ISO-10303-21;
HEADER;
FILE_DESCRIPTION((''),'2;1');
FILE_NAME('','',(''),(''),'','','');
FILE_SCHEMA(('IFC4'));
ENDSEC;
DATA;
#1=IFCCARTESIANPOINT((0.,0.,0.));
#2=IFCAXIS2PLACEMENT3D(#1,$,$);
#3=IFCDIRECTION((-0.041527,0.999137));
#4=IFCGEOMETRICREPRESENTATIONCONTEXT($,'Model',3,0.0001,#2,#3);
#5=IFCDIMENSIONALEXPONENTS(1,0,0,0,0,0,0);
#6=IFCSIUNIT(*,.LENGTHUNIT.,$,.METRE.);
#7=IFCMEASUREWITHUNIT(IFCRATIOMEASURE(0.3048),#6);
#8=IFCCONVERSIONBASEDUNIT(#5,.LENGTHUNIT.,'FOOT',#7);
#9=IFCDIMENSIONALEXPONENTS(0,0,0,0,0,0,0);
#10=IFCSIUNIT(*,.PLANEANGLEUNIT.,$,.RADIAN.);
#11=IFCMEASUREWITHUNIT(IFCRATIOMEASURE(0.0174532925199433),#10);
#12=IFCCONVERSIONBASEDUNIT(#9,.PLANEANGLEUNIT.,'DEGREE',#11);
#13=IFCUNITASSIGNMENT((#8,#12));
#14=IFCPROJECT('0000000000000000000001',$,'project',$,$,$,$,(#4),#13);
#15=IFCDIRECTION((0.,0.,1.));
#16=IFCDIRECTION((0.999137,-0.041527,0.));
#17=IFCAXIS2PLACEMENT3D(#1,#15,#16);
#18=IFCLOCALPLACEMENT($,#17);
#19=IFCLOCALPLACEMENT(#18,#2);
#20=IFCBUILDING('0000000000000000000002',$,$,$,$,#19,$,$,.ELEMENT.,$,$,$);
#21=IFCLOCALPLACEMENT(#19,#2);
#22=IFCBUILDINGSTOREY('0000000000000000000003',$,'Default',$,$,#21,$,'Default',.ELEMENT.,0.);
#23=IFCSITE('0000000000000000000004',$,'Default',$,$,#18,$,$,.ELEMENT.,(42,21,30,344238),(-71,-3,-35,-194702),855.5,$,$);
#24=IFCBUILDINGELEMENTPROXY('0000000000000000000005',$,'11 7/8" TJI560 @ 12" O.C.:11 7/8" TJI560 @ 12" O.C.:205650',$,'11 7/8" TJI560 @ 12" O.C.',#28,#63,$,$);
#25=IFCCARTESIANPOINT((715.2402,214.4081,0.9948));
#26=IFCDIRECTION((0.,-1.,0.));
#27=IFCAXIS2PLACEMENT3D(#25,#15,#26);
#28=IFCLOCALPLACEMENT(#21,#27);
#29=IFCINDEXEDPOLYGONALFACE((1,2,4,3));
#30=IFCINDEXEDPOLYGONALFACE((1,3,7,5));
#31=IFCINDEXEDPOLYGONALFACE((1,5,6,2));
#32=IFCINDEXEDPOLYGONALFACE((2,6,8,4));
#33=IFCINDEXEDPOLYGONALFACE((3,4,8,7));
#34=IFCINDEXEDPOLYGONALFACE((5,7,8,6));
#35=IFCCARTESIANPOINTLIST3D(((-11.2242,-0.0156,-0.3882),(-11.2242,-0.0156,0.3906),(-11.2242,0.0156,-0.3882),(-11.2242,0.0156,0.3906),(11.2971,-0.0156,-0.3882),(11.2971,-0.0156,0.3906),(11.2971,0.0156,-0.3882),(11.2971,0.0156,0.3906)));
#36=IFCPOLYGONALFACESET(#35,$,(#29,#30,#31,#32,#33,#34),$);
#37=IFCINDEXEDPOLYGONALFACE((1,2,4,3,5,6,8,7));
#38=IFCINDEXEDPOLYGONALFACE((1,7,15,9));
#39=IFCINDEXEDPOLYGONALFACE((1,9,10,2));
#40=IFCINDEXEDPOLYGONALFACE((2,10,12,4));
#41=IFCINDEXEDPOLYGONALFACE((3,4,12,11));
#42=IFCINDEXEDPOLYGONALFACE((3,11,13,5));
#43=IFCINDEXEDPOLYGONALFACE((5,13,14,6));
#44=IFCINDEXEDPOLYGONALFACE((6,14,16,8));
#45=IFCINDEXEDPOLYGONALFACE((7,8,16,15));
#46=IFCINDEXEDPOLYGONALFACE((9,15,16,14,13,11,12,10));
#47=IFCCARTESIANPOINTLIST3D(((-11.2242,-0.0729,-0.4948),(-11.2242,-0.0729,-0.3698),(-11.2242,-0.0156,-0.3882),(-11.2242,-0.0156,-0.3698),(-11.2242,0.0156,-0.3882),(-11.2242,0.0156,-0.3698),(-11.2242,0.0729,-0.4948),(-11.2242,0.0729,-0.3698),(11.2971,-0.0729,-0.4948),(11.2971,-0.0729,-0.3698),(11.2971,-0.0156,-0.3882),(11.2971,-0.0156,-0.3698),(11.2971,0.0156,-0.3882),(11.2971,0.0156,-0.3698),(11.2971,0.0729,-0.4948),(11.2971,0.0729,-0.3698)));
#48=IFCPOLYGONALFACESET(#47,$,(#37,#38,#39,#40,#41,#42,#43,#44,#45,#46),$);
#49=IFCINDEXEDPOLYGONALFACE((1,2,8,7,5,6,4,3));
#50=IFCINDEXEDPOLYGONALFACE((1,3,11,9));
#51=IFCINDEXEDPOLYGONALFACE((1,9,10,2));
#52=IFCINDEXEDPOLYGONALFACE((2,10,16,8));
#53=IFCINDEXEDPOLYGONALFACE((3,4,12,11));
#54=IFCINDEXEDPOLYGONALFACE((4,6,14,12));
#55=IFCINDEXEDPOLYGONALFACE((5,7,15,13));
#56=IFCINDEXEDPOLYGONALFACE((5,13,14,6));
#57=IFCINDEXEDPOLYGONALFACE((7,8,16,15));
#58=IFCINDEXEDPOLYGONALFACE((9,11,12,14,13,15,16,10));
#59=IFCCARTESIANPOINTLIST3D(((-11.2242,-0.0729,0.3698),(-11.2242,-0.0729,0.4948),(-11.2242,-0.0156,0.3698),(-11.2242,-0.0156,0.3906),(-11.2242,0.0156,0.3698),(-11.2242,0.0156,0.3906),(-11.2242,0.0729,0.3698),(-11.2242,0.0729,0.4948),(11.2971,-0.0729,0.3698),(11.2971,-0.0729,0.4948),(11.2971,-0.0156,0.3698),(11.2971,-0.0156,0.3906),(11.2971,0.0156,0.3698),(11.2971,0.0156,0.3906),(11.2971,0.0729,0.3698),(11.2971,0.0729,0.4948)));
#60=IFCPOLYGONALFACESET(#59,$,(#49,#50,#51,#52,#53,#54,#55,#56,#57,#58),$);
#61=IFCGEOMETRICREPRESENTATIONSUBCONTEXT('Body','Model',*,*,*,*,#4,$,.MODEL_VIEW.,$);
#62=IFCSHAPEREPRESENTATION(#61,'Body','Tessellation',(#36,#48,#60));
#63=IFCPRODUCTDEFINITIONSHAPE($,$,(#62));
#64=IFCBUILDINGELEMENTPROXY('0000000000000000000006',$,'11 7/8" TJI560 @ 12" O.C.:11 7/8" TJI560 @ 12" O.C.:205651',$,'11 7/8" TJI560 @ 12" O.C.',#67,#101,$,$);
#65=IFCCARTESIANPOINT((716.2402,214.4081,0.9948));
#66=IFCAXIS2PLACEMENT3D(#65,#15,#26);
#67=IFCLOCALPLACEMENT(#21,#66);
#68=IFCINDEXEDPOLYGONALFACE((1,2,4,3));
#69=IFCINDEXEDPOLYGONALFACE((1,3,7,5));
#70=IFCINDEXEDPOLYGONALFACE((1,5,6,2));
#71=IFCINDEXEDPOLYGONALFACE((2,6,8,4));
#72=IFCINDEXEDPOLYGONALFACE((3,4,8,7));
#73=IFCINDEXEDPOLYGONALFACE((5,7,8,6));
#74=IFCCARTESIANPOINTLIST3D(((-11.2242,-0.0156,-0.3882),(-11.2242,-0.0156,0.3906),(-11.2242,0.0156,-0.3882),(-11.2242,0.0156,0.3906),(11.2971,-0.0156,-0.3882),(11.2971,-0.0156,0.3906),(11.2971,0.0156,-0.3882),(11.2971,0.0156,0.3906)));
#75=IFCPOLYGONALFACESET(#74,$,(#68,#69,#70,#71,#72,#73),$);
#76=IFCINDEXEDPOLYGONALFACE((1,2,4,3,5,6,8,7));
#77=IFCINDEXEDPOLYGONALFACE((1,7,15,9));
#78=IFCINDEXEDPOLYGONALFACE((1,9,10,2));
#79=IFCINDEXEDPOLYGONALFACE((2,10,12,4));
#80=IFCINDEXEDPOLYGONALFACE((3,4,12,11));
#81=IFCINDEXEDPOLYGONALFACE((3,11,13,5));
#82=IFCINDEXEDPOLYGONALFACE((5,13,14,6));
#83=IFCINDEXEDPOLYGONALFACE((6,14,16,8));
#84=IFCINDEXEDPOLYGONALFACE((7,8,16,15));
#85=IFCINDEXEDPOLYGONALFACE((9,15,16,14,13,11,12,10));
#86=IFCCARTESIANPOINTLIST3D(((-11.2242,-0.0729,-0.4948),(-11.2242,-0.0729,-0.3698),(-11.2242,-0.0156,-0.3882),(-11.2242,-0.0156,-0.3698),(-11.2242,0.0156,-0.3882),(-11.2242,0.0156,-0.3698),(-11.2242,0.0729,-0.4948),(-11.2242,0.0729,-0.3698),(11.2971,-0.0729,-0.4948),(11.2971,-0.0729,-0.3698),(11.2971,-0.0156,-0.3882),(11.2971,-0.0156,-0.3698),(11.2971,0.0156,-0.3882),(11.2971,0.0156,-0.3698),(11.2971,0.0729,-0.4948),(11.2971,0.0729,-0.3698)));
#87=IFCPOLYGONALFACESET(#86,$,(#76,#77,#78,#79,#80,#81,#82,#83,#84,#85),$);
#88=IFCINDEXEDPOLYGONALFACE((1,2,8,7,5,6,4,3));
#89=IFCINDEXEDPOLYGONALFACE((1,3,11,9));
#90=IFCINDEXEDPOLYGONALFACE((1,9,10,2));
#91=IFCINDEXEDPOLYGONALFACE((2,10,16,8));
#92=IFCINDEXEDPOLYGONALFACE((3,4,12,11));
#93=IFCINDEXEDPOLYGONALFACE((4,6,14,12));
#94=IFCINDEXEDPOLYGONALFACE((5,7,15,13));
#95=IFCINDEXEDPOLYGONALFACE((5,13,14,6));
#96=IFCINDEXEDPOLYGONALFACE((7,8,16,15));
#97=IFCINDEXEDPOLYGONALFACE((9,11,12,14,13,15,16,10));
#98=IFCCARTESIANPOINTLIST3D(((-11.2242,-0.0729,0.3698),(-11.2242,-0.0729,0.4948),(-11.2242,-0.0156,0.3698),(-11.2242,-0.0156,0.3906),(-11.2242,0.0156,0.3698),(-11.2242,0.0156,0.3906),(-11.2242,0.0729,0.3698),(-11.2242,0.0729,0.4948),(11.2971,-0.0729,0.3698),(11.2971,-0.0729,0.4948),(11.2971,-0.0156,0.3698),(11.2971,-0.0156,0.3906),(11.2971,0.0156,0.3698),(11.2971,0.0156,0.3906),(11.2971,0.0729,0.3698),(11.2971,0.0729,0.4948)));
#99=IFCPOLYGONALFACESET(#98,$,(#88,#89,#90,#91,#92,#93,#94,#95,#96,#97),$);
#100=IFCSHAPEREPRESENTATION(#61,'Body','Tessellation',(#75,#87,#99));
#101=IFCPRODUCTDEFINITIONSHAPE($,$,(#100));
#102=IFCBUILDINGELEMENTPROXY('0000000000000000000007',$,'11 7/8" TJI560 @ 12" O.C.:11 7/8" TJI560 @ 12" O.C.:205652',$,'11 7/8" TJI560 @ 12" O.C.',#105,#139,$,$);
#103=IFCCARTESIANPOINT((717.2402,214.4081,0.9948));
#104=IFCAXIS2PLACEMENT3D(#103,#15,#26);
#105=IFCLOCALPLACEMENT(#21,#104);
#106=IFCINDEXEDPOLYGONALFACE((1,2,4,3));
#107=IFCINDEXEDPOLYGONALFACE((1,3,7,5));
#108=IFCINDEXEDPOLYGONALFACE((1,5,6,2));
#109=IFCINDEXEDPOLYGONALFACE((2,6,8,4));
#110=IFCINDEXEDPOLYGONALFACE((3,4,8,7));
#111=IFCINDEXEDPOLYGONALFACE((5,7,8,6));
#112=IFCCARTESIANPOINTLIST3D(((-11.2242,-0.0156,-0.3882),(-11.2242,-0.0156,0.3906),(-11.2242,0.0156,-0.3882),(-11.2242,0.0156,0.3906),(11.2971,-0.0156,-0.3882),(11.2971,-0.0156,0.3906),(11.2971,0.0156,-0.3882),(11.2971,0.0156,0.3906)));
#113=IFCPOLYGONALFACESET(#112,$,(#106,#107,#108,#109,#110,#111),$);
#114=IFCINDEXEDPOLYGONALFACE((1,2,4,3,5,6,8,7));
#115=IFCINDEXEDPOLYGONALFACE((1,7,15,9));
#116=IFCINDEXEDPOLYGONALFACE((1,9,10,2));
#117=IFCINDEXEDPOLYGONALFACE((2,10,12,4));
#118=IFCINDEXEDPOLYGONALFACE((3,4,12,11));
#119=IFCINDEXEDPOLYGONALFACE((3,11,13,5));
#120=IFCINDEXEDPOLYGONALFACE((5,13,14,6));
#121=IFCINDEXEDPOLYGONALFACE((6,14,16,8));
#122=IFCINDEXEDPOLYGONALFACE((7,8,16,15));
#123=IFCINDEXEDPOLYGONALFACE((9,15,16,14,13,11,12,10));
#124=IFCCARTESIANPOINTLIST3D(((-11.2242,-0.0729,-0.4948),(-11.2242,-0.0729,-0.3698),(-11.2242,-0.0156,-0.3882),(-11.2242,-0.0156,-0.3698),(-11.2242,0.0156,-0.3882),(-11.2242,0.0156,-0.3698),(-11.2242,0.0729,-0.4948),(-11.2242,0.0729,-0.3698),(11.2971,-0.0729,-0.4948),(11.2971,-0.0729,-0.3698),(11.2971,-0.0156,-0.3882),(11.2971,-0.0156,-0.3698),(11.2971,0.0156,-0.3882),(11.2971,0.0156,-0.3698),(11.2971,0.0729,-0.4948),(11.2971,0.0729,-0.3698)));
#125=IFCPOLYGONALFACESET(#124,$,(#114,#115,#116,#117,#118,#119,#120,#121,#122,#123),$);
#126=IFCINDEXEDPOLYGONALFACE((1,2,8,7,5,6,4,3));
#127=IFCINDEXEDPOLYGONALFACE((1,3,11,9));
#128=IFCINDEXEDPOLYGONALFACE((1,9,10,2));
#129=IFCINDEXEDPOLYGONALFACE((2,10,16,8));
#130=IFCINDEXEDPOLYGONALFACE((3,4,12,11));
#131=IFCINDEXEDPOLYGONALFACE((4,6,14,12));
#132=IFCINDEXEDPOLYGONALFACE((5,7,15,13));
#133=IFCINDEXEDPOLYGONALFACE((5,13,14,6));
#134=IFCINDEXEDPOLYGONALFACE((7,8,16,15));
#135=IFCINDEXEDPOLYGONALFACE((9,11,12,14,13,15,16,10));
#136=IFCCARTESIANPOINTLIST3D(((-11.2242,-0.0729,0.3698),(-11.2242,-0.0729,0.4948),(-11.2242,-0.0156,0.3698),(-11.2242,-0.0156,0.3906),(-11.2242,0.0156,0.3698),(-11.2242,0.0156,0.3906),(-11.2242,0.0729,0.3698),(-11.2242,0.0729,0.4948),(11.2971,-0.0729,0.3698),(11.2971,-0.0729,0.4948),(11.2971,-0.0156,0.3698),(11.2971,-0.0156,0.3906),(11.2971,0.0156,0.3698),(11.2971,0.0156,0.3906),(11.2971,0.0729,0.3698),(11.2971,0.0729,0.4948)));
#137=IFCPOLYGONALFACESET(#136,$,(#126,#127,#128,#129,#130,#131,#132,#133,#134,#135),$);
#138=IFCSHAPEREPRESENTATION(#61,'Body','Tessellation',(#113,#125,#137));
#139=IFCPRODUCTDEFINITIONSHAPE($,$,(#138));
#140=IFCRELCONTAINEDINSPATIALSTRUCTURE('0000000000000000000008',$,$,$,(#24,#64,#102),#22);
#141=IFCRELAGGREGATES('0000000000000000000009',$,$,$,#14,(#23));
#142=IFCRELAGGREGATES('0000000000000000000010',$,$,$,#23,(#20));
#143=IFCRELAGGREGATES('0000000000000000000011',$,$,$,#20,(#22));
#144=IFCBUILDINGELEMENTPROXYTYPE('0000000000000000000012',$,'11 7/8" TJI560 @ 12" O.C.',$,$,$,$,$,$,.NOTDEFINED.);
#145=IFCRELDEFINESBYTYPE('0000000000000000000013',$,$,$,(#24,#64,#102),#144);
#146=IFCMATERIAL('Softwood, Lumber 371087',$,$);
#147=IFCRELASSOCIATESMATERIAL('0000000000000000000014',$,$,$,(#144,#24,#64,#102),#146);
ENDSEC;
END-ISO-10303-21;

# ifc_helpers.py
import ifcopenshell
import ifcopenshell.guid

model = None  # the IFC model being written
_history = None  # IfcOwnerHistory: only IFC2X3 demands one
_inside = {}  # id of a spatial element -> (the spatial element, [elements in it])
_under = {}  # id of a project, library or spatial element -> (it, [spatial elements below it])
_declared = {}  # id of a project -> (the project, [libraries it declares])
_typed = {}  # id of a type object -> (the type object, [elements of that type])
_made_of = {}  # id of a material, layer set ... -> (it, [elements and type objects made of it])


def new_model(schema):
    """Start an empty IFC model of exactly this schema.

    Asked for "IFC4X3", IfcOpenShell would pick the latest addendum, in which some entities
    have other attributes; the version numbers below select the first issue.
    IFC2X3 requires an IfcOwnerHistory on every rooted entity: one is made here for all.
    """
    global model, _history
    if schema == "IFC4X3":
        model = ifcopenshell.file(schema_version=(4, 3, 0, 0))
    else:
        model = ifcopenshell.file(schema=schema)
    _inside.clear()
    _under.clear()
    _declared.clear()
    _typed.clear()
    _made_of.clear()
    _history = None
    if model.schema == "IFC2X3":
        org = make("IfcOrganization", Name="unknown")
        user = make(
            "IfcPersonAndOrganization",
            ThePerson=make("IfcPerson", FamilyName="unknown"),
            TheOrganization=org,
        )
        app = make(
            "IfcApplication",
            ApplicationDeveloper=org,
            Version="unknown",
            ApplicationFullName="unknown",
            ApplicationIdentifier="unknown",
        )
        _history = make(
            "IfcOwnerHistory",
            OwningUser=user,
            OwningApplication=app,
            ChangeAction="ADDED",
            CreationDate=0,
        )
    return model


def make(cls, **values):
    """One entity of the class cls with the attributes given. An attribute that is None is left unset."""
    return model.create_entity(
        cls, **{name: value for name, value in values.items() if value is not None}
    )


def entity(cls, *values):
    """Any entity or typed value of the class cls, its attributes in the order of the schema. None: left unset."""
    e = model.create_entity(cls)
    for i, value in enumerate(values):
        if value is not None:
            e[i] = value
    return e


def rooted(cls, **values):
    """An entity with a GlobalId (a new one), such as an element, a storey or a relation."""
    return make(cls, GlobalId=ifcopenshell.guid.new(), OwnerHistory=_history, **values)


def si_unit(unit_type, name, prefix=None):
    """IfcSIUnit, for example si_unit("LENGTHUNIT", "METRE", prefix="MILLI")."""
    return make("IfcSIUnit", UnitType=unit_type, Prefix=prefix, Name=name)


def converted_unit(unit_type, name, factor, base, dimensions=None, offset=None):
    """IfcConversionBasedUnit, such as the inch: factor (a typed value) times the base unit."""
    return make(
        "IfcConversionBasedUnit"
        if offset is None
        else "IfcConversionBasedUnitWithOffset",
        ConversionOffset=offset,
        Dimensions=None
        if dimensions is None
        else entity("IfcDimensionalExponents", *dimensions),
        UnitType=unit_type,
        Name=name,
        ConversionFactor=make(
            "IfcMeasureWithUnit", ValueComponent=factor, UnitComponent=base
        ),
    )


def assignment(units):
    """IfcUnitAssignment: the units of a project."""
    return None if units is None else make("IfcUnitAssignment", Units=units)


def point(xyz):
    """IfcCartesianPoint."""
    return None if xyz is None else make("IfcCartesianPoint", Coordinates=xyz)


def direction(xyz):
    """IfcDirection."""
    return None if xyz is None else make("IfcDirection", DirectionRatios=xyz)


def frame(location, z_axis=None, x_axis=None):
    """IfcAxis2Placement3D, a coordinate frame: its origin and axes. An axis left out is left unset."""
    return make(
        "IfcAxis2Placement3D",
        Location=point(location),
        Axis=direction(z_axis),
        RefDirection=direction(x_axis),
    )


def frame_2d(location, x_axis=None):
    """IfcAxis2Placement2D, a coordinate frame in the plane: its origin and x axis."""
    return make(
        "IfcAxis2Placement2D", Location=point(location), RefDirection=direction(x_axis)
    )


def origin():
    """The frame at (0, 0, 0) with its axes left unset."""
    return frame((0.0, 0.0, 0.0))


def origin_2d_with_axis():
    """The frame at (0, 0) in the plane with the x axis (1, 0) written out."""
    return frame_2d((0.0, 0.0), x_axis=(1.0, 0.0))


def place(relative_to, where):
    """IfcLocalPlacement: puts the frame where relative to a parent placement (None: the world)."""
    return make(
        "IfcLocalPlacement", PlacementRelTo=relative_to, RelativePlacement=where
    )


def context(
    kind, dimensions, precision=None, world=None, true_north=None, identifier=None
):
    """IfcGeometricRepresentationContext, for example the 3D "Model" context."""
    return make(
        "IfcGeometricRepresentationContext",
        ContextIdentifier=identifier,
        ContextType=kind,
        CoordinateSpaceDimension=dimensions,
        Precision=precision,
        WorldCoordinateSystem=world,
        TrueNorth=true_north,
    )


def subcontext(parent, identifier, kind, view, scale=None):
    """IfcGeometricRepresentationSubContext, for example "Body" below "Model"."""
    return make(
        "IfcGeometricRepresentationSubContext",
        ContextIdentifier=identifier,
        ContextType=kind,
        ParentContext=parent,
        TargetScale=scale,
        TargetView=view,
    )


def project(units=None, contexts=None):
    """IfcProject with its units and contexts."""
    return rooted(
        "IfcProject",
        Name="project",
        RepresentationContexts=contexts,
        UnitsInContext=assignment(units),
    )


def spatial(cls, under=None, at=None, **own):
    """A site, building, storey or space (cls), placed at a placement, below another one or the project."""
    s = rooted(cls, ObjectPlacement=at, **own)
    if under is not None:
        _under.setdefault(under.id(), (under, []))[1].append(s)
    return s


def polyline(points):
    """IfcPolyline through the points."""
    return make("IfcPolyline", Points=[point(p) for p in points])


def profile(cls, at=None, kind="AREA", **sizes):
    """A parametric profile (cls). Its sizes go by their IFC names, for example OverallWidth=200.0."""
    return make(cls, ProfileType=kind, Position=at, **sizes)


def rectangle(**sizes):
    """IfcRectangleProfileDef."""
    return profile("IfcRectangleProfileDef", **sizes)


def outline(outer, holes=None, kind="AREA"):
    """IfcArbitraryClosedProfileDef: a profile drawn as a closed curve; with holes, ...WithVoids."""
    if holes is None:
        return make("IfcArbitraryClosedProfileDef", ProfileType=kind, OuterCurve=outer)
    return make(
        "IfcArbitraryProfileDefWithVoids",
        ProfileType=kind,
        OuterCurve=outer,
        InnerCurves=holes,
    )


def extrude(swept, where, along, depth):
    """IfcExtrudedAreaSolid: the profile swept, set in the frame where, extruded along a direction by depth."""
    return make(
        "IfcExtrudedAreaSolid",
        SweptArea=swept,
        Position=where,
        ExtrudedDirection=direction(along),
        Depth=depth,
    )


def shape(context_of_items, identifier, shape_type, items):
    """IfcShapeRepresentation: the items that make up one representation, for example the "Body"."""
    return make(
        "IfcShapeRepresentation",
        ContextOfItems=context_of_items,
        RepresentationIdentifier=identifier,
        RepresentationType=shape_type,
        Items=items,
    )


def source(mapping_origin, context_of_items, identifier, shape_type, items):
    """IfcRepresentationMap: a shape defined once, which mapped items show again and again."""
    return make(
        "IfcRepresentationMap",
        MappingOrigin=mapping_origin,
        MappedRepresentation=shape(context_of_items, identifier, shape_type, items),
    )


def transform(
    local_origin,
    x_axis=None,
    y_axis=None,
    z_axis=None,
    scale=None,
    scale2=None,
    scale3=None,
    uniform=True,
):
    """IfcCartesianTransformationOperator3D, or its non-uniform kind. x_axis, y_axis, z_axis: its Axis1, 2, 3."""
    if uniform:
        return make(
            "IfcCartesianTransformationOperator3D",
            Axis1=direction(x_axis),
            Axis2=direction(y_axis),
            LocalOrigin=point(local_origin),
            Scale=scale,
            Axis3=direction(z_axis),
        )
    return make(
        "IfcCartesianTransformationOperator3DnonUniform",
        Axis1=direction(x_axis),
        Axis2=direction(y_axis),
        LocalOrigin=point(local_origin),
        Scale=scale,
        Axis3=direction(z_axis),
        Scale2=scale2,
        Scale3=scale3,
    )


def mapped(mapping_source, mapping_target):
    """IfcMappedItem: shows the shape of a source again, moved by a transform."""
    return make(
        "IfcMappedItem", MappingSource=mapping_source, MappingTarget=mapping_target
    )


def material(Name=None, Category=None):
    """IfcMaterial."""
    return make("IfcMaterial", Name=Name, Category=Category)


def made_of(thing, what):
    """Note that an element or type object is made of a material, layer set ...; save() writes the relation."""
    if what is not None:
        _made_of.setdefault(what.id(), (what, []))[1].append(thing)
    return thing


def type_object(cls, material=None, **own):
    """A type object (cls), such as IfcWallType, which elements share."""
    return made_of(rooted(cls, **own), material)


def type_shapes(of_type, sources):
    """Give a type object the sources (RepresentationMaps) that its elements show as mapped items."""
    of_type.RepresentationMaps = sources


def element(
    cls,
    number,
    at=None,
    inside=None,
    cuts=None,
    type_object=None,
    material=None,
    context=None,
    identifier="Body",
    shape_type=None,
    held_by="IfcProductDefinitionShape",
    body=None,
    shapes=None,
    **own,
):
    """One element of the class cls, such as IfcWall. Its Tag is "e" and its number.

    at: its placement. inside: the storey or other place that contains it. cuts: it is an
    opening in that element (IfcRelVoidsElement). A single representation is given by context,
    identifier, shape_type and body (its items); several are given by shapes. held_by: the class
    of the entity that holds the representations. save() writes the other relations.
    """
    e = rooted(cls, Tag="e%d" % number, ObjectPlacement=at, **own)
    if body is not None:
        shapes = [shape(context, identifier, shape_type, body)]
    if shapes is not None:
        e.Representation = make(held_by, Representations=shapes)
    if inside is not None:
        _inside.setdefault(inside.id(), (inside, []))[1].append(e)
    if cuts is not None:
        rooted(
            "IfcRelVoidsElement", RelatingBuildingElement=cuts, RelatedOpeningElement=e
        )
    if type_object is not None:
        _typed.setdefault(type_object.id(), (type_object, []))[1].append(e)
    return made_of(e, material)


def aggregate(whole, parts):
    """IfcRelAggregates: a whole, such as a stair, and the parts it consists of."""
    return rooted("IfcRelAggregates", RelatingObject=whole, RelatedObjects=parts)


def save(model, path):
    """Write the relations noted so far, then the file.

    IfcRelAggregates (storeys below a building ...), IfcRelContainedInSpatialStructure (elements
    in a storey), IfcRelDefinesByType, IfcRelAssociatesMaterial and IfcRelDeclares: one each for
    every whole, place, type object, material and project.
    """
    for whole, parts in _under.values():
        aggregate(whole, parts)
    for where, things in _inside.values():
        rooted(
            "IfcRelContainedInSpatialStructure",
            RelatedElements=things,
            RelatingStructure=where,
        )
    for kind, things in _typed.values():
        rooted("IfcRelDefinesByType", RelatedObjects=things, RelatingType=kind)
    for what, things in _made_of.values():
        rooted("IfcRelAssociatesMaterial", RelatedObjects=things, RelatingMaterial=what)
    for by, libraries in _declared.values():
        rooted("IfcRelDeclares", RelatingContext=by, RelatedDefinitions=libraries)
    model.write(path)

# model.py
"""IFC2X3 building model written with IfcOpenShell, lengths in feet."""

from ifc_helpers import new_model, entity, si_unit, converted_unit, direction, frame, origin, origin_2d_with_axis, place, context, subcontext, project, spatial, polyline, rectangle, outline, extrude, source, transform, mapped, material, type_object, type_shapes, element, save


model = new_model("IFC2X3")

# Units and contexts
model_context = context("Model", 3, precision=0.0001, world=origin(), true_north=direction((-0.041527, 0.999137)))
body_context = subcontext(model_context, "Body", "Model", "MODEL_VIEW")
ifc_project = project(units=[converted_unit("LENGTHUNIT", "FOOT", entity("IfcRatioMeasure", 0.3048), si_unit("LENGTHUNIT", "METRE"), dimensions=[1, 0, 0, 0, 0, 0, 0]), converted_unit("PLANEANGLEUNIT", "DEGREE", entity("IfcRatioMeasure", 0.0174532925199433), si_unit("PLANEANGLEUNIT", "RADIAN"), dimensions=[0, 0, 0, 0, 0, 0, 0])], contexts=[model_context])

# Site, building, storey
site_placement = place(None, frame((0.0, 0.0, 0.0), z_axis=(0.0, 0.0, 1.0), x_axis=(0.999137, -0.041527, 0.0)))
site = spatial("IfcSite", under=ifc_project, at=site_placement, Name="Default", CompositionType="ELEMENT", RefLatitude=(42, 21, 30, 344238), RefLongitude=(-71, -3, -35, -194702), RefElevation=855.5)
building_placement = place(site_placement, origin())
building = spatial("IfcBuilding", under=site, at=building_placement, CompositionType="ELEMENT")
storey_placement = place(building_placement, origin())
storey = spatial("IfcBuildingStorey", under=building, at=storey_placement, Name="Default", LongName="Default", CompositionType="ELEMENT", Elevation=0.0)

# Building element proxies
ifc_material = material(Name="Softwood, Lumber 371087")
building_element_proxy_type_1 = type_object("IfcBuildingElementProxyType", Name="11 7/8\" TJI560 @ 12\" O.C.", PredefinedType="NOTDEFINED", material=ifc_material)
shared_shape_1 = source(origin(), body_context, "Body", "SweptSolid", [
    extrude(rectangle(XDim=22.5212, YDim=0.0313, at=origin_2d_with_axis()), frame((0.0365, 0.0, -0.3882), z_axis=(0.0, 0.0, 1.0), x_axis=(-1.0, 0.0, 0.0)), (0.0, 0.0, 1.0), 0.7788),
    extrude(outline(polyline([(-0.0891, -0.0729), (0.0359, -0.0729), (0.0359, -0.0156), (0.0174, -0.0156), (0.0174, 0.0156), (0.0359, 0.0156), (0.0359, 0.0729), (-0.0891, 0.0729), (-0.0891, -0.0729)])), frame((-11.2242, 0.0, -0.4056), z_axis=(1.0, 0.0, 0.0), x_axis=(0.0, 0.0, 1.0)), (0.0, 0.0, 1.0), 22.5212),
    extrude(outline(polyline([(-0.0729, -0.0885), (0.0729, -0.0885), (0.0729, 0.0365), (0.0156, 0.0365), (0.0156, 0.0156), (-0.0156, 0.0156), (-0.0156, 0.0365), (-0.0729, 0.0365), (-0.0729, -0.0885)])), frame((-11.2242, 0.0, 0.4062), z_axis=(1.0, 0.0, 0.0), x_axis=(0.0, -1.0, 0.0)), (0.0, 0.0, 1.0), 22.5212),
])
type_shapes(building_element_proxy_type_1, [shared_shape_1])
for number, where, z_axis, x_axis, name in (
    (1, (715.2402, 214.4081, 0.9948), (0.0, 0.0, 1.0), (0.0, -1.0, 0.0), "11 7/8\" TJI560 @ 12\" O.C.:11 7/8\" TJI560 @ 12\" O.C.:205650"),
    (2, (716.2402, 214.4081, 0.9948), (0.0, 0.0, 1.0), (0.0, -1.0, 0.0), "11 7/8\" TJI560 @ 12\" O.C.:11 7/8\" TJI560 @ 12\" O.C.:205651"),
    (3, (717.2402, 214.4081, 0.9948), (0.0, 0.0, 1.0), (0.0, -1.0, 0.0), "11 7/8\" TJI560 @ 12\" O.C.:11 7/8\" TJI560 @ 12\" O.C.:205652"),
):
    element("IfcBuildingElementProxy", number, at=place(storey_placement, frame(where, z_axis=z_axis, x_axis=x_axis)), inside=storey, type_object=building_element_proxy_type_1, material=ifc_material, Name=name, ObjectType="11 7/8\" TJI560 @ 12\" O.C.", context=body_context, shape_type="MappedRepresentation", body=[
        mapped(shared_shape_1, transform((0.0, 0.0, 0.0), scale=1.0)),
    ])

save(model, "model.ifc")
